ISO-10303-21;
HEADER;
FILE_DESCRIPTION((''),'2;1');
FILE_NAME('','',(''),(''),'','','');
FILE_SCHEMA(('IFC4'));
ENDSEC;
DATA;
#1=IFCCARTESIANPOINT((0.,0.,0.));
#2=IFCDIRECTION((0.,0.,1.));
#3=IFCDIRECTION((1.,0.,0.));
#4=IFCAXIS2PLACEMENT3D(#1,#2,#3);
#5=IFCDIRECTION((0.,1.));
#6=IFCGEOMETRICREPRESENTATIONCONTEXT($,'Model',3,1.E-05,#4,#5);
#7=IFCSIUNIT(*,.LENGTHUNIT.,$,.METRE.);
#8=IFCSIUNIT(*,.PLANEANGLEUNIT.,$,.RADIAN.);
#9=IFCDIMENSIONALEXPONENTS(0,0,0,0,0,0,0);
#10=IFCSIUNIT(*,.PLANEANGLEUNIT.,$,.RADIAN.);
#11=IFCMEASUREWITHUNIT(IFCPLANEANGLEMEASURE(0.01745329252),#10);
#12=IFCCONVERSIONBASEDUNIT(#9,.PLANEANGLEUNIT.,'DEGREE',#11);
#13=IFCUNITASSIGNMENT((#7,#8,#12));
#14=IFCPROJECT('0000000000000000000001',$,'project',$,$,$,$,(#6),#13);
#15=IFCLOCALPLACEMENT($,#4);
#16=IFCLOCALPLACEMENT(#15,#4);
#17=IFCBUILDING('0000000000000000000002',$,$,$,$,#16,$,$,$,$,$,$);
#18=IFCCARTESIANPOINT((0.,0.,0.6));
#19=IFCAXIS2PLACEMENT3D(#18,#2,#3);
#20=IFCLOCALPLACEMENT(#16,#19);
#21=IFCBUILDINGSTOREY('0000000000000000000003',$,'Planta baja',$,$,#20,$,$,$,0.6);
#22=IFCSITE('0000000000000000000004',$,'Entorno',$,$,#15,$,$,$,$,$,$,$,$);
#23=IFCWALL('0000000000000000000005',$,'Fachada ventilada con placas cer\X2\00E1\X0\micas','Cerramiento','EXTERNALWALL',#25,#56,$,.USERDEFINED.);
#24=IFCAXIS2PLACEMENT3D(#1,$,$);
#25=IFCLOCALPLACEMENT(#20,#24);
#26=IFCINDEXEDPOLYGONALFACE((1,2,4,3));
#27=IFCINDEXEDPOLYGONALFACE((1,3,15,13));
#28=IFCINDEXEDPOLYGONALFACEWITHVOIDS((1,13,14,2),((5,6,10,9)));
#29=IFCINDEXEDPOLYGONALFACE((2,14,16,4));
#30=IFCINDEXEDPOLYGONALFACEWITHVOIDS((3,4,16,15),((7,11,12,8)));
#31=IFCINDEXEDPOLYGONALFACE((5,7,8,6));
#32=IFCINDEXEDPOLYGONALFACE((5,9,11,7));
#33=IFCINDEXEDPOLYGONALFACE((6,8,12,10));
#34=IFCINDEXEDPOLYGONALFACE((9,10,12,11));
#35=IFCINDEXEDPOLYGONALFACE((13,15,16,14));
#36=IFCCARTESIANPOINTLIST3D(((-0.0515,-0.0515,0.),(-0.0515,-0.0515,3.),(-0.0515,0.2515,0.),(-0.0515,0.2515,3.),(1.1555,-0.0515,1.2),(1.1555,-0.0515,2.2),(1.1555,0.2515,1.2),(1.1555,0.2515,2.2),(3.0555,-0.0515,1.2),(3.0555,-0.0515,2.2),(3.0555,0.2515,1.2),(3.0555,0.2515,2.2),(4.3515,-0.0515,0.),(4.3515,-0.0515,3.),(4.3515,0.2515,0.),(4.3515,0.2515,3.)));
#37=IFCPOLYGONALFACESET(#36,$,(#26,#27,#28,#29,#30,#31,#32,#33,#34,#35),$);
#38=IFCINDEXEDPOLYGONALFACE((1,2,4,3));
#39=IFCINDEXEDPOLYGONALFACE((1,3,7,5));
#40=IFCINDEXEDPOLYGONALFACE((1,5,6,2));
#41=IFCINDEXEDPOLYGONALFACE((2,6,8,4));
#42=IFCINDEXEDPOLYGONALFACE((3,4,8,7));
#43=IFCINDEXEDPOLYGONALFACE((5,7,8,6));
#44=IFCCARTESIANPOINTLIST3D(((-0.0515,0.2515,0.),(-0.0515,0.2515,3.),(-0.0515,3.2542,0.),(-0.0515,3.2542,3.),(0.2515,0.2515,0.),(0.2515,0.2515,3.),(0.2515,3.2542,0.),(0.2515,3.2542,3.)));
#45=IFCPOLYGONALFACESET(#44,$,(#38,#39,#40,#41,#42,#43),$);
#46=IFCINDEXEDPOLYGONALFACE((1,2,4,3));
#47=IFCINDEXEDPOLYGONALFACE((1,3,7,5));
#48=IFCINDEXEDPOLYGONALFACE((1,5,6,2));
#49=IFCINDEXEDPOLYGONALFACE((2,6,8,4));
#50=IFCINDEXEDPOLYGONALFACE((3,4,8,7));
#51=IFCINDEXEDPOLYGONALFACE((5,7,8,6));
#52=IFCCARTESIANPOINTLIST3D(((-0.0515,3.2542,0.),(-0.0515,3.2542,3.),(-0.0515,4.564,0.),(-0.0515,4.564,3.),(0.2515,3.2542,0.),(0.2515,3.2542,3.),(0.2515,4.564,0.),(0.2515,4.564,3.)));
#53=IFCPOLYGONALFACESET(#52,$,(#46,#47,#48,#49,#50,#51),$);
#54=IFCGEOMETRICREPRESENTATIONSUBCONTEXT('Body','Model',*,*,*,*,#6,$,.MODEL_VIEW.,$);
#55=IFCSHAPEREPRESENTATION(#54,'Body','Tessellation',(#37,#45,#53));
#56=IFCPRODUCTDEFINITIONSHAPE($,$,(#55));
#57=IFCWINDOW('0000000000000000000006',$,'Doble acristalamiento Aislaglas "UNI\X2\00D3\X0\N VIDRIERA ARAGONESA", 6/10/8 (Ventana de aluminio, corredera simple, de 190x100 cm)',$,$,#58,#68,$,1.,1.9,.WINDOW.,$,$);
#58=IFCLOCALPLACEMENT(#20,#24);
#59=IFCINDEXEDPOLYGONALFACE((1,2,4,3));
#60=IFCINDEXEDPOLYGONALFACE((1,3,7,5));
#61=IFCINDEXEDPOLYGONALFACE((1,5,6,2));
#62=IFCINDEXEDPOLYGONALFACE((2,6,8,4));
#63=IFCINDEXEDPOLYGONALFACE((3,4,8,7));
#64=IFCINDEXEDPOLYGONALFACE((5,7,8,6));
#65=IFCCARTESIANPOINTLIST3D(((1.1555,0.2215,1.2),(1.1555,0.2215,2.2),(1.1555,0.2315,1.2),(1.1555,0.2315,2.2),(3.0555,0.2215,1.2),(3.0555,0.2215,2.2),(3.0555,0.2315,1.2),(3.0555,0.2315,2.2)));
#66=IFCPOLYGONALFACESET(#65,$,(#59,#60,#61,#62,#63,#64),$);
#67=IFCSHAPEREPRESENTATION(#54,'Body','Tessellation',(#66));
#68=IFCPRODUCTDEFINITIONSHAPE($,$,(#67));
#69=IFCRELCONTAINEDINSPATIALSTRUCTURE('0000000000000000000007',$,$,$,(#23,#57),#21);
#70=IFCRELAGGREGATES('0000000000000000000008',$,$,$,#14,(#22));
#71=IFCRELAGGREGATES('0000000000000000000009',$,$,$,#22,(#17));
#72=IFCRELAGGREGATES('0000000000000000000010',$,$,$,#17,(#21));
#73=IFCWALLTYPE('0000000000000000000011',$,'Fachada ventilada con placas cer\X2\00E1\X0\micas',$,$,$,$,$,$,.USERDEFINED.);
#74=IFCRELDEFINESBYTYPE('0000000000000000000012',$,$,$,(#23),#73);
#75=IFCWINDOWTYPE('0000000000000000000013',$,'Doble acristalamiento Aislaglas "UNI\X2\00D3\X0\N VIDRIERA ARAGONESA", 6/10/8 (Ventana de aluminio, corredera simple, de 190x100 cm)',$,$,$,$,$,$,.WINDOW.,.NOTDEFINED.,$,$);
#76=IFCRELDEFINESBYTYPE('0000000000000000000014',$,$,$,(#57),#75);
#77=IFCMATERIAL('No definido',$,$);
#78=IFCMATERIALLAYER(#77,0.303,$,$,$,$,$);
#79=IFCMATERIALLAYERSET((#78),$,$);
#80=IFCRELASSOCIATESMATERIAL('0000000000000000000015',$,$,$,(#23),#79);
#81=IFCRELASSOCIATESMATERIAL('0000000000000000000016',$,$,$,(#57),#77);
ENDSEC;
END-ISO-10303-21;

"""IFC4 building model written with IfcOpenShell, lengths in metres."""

from ifc_helpers import new_model, entity, si_unit, converted_unit, direction, frame, origin_with_axes, origin_2d_with_axis, place, context, subcontext, project, spatial, rectangle, extrude, shape, material, layer, layer_set, layer_usage, type_object, element, fill, save


model = new_model("IFC4")

# Units and contexts
model_context = context("Model", 3, precision=1e-05, world=origin_with_axes(), true_north=direction((0.0, 1.0)))
body_context = subcontext(model_context, "Body", "Model", "MODEL_VIEW")
footprint_context = subcontext(model_context, "FootPrint", "Model", "MODEL_VIEW")
ifc_project = project(units=[si_unit("LENGTHUNIT", "METRE"), si_unit("PLANEANGLEUNIT", "RADIAN"), converted_unit("PLANEANGLEUNIT", "DEGREE", entity("IfcPlaneAngleMeasure", 0.01745329252), si_unit("PLANEANGLEUNIT", "RADIAN"), dimensions=[0, 0, 0, 0, 0, 0, 0])], contexts=[model_context])

# Site, building, storey
site_placement = place(None, origin_with_axes())
site = spatial("IfcSite", under=ifc_project, at=site_placement, Name="Entorno")
building_placement = place(site_placement, origin_with_axes())
building = spatial("IfcBuilding", under=site, at=building_placement)
storey_placement = place(building_placement, frame((0.0, 0.0, 0.6), z_axis=(0.0, 0.0, 1.0), x_axis=(1.0, 0.0, 0.0)))
storey = spatial("IfcBuildingStorey", under=building, at=storey_placement, Name="Planta baja", Elevation=0.6)

# Shared definitions
ifc_material = material(Name="No definido")

# Shared definitions
wall_type_1 = type_object("IfcWallType", Name="Fachada ventilada con placas cerámicas", PredefinedType="USERDEFINED")

# Wall, opening, window
ifc_layer_1 = layer(ifc_material, 0.303)
ifc_layer_set_1 = layer_set([ifc_layer_1])
ifc_layer_usage_1 = layer_usage(ifc_layer_set_1, "AXIS2", "POSITIVE", -0.1515)
wall_1_placement = place(storey_placement, frame((4.2, 0.1, 0.0), z_axis=(0.0, 0.0, 1.0), x_axis=(-1.0, 0.0, 0.0)))
cartesian_point_1 = entity("IfcCartesianPoint", [-2.2015, -1.5])
cartesian_point_2 = entity("IfcCartesianPoint", [-2.2015, -1.5])
cartesian_point_3 = entity("IfcCartesianPoint", [-1.5013, -1.5])
cartesian_point_4 = entity("IfcCartesianPoint", [-1.5013, -1.5])
cartesian_point_5 = entity("IfcCartesianPoint", [-0.6549, -1.5])
cartesian_point_6 = entity("IfcCartesianPoint", [-0.6549, -1.5])
wall_1 = element("IfcWall", 1, at=wall_1_placement, inside=storey, type_object=wall_type_1, material=ifc_layer_usage_1, Name="Fachada ventilada con placas cerámicas", Description="Cerramiento", ObjectType="EXTERNALWALL", PredefinedType="USERDEFINED", context=body_context, shape_type="SolidModel", body=[
    entity("IfcExtrudedAreaSolidTapered", entity("IfcArbitraryClosedProfileDef", "AREA", None, entity("IfcPolyline", [cartesian_point_1, entity("IfcCartesianPoint", [2.2015, -1.5]), entity("IfcCartesianPoint", [2.2015, 1.5]), entity("IfcCartesianPoint", [-2.2015, 1.5]), cartesian_point_1])), entity("IfcAxis2Placement3D", entity("IfcCartesianPoint", [2.05, 0.1515, 1.5]), entity("IfcDirection", [0.0, -1.0, 0.0]), entity("IfcDirection", [1.0, 0.0, 0.0])), entity("IfcDirection", [0.0, 0.0, 1.0]), 0.303, entity("IfcArbitraryClosedProfileDef", "AREA", None, entity("IfcPolyline", [cartesian_point_2, entity("IfcCartesianPoint", [2.2015, -1.5]), entity("IfcCartesianPoint", [2.2015, 1.5]), entity("IfcCartesianPoint", [-2.2015, 1.5]), cartesian_point_2]))),
    entity("IfcExtrudedAreaSolidTapered", entity("IfcArbitraryClosedProfileDef", "AREA", None, entity("IfcPolyline", [cartesian_point_3, entity("IfcCartesianPoint", [1.5013, -1.5]), entity("IfcCartesianPoint", [1.5013, 1.5]), entity("IfcCartesianPoint", [-1.5013, 1.5]), cartesian_point_3])), entity("IfcAxis2Placement3D", entity("IfcCartesianPoint", [4.2515, -1.6528, 1.5]), entity("IfcDirection", [-1.0, 0.0, 0.0]), entity("IfcDirection", [0.0, -1.0, 0.0])), entity("IfcDirection", [0.0, 0.0, 1.0]), 0.303, entity("IfcArbitraryClosedProfileDef", "AREA", None, entity("IfcPolyline", [cartesian_point_4, entity("IfcCartesianPoint", [1.5013, -1.5]), entity("IfcCartesianPoint", [1.5013, 1.5]), entity("IfcCartesianPoint", [-1.5013, 1.5]), cartesian_point_4]))),
    entity("IfcExtrudedAreaSolidTapered", entity("IfcArbitraryClosedProfileDef", "AREA", None, entity("IfcPolyline", [cartesian_point_5, entity("IfcCartesianPoint", [0.6549, -1.5]), entity("IfcCartesianPoint", [0.6549, 1.5]), entity("IfcCartesianPoint", [-0.6549, 1.5]), cartesian_point_5])), entity("IfcAxis2Placement3D", entity("IfcCartesianPoint", [4.2515, -3.8091, 1.5]), entity("IfcDirection", [-1.0, 0.0, 0.0]), entity("IfcDirection", [0.0, -1.0, 0.0])), entity("IfcDirection", [0.0, 0.0, 1.0]), 0.303, entity("IfcArbitraryClosedProfileDef", "AREA", None, entity("IfcPolyline", [cartesian_point_6, entity("IfcCartesianPoint", [0.6549, -1.5]), entity("IfcCartesianPoint", [0.6549, 1.5]), entity("IfcCartesianPoint", [-0.6549, 1.5]), cartesian_point_6]))),
])
opening_1_placement = place(wall_1_placement, frame((2.0945, 0.0, 1.7), z_axis=(0.0, 0.0, 1.0), x_axis=(1.0, 0.0, 0.0)))
cartesian_point_7 = entity("IfcCartesianPoint", [-0.95, -0.1515])
opening_1 = element("IfcOpeningElement", 2, at=opening_1_placement, cuts=wall_1, ObjectType="No definido", PredefinedType="OPENING", shapes=[
    shape(body_context, "Body", "SweptSolid", [extrude(rectangle(XDim=1.0, YDim=1.9, at=origin_2d_with_axis()), frame((0.0, -0.1515, 0.0), z_axis=(0.0, 1.0, 0.0), x_axis=(0.0, 0.0, 1.0)), (0.0, 0.0, 1.0), 0.303)]),
    shape(footprint_context, "FootPrint", "GeometricCurveSet", [entity("IfcGeometricCurveSet", [entity("IfcPolyline", [cartesian_point_7, entity("IfcCartesianPoint", [0.95, -0.1515]), entity("IfcCartesianPoint", [0.95, 0.1515]), entity("IfcCartesianPoint", [-0.95, 0.1515]), cartesian_point_7])])]),
])
window_type_1 = type_object("IfcWindowType", Name="Doble acristalamiento Aislaglas \"UNIÓN VIDRIERA ARAGONESA\", 6/10/8 (Ventana de aluminio, corredera simple, de 190x100 cm)", PartitioningType="NOTDEFINED", PredefinedType="WINDOW")
window_1_placement = place(opening_1_placement, frame((0.0, -0.1265, 0.0), z_axis=(0.0, 0.0, 1.0), x_axis=(1.0, 0.0, 0.0)))
window_1 = element("IfcWindow", 3, at=window_1_placement, inside=storey, type_object=window_type_1, material=ifc_material, Name="Doble acristalamiento Aislaglas \"UNIÓN VIDRIERA ARAGONESA\", 6/10/8 (Ventana de aluminio, corredera simple, de 190x100 cm)", OverallHeight=1.0, OverallWidth=1.9, PredefinedType="WINDOW", context=body_context, shape_type="SweptSolid", body=[
    extrude(rectangle(XDim=1.9, YDim=1.0, at=origin_2d_with_axis()), frame((0.0, 0.005, 0.0), z_axis=(0.0, -1.0, 0.0), x_axis=(1.0, 0.0, 0.0)), (0.0, 0.0, 1.0), 0.01),
])
fill(opening_1, window_1)

save(model, "model.ifc")
